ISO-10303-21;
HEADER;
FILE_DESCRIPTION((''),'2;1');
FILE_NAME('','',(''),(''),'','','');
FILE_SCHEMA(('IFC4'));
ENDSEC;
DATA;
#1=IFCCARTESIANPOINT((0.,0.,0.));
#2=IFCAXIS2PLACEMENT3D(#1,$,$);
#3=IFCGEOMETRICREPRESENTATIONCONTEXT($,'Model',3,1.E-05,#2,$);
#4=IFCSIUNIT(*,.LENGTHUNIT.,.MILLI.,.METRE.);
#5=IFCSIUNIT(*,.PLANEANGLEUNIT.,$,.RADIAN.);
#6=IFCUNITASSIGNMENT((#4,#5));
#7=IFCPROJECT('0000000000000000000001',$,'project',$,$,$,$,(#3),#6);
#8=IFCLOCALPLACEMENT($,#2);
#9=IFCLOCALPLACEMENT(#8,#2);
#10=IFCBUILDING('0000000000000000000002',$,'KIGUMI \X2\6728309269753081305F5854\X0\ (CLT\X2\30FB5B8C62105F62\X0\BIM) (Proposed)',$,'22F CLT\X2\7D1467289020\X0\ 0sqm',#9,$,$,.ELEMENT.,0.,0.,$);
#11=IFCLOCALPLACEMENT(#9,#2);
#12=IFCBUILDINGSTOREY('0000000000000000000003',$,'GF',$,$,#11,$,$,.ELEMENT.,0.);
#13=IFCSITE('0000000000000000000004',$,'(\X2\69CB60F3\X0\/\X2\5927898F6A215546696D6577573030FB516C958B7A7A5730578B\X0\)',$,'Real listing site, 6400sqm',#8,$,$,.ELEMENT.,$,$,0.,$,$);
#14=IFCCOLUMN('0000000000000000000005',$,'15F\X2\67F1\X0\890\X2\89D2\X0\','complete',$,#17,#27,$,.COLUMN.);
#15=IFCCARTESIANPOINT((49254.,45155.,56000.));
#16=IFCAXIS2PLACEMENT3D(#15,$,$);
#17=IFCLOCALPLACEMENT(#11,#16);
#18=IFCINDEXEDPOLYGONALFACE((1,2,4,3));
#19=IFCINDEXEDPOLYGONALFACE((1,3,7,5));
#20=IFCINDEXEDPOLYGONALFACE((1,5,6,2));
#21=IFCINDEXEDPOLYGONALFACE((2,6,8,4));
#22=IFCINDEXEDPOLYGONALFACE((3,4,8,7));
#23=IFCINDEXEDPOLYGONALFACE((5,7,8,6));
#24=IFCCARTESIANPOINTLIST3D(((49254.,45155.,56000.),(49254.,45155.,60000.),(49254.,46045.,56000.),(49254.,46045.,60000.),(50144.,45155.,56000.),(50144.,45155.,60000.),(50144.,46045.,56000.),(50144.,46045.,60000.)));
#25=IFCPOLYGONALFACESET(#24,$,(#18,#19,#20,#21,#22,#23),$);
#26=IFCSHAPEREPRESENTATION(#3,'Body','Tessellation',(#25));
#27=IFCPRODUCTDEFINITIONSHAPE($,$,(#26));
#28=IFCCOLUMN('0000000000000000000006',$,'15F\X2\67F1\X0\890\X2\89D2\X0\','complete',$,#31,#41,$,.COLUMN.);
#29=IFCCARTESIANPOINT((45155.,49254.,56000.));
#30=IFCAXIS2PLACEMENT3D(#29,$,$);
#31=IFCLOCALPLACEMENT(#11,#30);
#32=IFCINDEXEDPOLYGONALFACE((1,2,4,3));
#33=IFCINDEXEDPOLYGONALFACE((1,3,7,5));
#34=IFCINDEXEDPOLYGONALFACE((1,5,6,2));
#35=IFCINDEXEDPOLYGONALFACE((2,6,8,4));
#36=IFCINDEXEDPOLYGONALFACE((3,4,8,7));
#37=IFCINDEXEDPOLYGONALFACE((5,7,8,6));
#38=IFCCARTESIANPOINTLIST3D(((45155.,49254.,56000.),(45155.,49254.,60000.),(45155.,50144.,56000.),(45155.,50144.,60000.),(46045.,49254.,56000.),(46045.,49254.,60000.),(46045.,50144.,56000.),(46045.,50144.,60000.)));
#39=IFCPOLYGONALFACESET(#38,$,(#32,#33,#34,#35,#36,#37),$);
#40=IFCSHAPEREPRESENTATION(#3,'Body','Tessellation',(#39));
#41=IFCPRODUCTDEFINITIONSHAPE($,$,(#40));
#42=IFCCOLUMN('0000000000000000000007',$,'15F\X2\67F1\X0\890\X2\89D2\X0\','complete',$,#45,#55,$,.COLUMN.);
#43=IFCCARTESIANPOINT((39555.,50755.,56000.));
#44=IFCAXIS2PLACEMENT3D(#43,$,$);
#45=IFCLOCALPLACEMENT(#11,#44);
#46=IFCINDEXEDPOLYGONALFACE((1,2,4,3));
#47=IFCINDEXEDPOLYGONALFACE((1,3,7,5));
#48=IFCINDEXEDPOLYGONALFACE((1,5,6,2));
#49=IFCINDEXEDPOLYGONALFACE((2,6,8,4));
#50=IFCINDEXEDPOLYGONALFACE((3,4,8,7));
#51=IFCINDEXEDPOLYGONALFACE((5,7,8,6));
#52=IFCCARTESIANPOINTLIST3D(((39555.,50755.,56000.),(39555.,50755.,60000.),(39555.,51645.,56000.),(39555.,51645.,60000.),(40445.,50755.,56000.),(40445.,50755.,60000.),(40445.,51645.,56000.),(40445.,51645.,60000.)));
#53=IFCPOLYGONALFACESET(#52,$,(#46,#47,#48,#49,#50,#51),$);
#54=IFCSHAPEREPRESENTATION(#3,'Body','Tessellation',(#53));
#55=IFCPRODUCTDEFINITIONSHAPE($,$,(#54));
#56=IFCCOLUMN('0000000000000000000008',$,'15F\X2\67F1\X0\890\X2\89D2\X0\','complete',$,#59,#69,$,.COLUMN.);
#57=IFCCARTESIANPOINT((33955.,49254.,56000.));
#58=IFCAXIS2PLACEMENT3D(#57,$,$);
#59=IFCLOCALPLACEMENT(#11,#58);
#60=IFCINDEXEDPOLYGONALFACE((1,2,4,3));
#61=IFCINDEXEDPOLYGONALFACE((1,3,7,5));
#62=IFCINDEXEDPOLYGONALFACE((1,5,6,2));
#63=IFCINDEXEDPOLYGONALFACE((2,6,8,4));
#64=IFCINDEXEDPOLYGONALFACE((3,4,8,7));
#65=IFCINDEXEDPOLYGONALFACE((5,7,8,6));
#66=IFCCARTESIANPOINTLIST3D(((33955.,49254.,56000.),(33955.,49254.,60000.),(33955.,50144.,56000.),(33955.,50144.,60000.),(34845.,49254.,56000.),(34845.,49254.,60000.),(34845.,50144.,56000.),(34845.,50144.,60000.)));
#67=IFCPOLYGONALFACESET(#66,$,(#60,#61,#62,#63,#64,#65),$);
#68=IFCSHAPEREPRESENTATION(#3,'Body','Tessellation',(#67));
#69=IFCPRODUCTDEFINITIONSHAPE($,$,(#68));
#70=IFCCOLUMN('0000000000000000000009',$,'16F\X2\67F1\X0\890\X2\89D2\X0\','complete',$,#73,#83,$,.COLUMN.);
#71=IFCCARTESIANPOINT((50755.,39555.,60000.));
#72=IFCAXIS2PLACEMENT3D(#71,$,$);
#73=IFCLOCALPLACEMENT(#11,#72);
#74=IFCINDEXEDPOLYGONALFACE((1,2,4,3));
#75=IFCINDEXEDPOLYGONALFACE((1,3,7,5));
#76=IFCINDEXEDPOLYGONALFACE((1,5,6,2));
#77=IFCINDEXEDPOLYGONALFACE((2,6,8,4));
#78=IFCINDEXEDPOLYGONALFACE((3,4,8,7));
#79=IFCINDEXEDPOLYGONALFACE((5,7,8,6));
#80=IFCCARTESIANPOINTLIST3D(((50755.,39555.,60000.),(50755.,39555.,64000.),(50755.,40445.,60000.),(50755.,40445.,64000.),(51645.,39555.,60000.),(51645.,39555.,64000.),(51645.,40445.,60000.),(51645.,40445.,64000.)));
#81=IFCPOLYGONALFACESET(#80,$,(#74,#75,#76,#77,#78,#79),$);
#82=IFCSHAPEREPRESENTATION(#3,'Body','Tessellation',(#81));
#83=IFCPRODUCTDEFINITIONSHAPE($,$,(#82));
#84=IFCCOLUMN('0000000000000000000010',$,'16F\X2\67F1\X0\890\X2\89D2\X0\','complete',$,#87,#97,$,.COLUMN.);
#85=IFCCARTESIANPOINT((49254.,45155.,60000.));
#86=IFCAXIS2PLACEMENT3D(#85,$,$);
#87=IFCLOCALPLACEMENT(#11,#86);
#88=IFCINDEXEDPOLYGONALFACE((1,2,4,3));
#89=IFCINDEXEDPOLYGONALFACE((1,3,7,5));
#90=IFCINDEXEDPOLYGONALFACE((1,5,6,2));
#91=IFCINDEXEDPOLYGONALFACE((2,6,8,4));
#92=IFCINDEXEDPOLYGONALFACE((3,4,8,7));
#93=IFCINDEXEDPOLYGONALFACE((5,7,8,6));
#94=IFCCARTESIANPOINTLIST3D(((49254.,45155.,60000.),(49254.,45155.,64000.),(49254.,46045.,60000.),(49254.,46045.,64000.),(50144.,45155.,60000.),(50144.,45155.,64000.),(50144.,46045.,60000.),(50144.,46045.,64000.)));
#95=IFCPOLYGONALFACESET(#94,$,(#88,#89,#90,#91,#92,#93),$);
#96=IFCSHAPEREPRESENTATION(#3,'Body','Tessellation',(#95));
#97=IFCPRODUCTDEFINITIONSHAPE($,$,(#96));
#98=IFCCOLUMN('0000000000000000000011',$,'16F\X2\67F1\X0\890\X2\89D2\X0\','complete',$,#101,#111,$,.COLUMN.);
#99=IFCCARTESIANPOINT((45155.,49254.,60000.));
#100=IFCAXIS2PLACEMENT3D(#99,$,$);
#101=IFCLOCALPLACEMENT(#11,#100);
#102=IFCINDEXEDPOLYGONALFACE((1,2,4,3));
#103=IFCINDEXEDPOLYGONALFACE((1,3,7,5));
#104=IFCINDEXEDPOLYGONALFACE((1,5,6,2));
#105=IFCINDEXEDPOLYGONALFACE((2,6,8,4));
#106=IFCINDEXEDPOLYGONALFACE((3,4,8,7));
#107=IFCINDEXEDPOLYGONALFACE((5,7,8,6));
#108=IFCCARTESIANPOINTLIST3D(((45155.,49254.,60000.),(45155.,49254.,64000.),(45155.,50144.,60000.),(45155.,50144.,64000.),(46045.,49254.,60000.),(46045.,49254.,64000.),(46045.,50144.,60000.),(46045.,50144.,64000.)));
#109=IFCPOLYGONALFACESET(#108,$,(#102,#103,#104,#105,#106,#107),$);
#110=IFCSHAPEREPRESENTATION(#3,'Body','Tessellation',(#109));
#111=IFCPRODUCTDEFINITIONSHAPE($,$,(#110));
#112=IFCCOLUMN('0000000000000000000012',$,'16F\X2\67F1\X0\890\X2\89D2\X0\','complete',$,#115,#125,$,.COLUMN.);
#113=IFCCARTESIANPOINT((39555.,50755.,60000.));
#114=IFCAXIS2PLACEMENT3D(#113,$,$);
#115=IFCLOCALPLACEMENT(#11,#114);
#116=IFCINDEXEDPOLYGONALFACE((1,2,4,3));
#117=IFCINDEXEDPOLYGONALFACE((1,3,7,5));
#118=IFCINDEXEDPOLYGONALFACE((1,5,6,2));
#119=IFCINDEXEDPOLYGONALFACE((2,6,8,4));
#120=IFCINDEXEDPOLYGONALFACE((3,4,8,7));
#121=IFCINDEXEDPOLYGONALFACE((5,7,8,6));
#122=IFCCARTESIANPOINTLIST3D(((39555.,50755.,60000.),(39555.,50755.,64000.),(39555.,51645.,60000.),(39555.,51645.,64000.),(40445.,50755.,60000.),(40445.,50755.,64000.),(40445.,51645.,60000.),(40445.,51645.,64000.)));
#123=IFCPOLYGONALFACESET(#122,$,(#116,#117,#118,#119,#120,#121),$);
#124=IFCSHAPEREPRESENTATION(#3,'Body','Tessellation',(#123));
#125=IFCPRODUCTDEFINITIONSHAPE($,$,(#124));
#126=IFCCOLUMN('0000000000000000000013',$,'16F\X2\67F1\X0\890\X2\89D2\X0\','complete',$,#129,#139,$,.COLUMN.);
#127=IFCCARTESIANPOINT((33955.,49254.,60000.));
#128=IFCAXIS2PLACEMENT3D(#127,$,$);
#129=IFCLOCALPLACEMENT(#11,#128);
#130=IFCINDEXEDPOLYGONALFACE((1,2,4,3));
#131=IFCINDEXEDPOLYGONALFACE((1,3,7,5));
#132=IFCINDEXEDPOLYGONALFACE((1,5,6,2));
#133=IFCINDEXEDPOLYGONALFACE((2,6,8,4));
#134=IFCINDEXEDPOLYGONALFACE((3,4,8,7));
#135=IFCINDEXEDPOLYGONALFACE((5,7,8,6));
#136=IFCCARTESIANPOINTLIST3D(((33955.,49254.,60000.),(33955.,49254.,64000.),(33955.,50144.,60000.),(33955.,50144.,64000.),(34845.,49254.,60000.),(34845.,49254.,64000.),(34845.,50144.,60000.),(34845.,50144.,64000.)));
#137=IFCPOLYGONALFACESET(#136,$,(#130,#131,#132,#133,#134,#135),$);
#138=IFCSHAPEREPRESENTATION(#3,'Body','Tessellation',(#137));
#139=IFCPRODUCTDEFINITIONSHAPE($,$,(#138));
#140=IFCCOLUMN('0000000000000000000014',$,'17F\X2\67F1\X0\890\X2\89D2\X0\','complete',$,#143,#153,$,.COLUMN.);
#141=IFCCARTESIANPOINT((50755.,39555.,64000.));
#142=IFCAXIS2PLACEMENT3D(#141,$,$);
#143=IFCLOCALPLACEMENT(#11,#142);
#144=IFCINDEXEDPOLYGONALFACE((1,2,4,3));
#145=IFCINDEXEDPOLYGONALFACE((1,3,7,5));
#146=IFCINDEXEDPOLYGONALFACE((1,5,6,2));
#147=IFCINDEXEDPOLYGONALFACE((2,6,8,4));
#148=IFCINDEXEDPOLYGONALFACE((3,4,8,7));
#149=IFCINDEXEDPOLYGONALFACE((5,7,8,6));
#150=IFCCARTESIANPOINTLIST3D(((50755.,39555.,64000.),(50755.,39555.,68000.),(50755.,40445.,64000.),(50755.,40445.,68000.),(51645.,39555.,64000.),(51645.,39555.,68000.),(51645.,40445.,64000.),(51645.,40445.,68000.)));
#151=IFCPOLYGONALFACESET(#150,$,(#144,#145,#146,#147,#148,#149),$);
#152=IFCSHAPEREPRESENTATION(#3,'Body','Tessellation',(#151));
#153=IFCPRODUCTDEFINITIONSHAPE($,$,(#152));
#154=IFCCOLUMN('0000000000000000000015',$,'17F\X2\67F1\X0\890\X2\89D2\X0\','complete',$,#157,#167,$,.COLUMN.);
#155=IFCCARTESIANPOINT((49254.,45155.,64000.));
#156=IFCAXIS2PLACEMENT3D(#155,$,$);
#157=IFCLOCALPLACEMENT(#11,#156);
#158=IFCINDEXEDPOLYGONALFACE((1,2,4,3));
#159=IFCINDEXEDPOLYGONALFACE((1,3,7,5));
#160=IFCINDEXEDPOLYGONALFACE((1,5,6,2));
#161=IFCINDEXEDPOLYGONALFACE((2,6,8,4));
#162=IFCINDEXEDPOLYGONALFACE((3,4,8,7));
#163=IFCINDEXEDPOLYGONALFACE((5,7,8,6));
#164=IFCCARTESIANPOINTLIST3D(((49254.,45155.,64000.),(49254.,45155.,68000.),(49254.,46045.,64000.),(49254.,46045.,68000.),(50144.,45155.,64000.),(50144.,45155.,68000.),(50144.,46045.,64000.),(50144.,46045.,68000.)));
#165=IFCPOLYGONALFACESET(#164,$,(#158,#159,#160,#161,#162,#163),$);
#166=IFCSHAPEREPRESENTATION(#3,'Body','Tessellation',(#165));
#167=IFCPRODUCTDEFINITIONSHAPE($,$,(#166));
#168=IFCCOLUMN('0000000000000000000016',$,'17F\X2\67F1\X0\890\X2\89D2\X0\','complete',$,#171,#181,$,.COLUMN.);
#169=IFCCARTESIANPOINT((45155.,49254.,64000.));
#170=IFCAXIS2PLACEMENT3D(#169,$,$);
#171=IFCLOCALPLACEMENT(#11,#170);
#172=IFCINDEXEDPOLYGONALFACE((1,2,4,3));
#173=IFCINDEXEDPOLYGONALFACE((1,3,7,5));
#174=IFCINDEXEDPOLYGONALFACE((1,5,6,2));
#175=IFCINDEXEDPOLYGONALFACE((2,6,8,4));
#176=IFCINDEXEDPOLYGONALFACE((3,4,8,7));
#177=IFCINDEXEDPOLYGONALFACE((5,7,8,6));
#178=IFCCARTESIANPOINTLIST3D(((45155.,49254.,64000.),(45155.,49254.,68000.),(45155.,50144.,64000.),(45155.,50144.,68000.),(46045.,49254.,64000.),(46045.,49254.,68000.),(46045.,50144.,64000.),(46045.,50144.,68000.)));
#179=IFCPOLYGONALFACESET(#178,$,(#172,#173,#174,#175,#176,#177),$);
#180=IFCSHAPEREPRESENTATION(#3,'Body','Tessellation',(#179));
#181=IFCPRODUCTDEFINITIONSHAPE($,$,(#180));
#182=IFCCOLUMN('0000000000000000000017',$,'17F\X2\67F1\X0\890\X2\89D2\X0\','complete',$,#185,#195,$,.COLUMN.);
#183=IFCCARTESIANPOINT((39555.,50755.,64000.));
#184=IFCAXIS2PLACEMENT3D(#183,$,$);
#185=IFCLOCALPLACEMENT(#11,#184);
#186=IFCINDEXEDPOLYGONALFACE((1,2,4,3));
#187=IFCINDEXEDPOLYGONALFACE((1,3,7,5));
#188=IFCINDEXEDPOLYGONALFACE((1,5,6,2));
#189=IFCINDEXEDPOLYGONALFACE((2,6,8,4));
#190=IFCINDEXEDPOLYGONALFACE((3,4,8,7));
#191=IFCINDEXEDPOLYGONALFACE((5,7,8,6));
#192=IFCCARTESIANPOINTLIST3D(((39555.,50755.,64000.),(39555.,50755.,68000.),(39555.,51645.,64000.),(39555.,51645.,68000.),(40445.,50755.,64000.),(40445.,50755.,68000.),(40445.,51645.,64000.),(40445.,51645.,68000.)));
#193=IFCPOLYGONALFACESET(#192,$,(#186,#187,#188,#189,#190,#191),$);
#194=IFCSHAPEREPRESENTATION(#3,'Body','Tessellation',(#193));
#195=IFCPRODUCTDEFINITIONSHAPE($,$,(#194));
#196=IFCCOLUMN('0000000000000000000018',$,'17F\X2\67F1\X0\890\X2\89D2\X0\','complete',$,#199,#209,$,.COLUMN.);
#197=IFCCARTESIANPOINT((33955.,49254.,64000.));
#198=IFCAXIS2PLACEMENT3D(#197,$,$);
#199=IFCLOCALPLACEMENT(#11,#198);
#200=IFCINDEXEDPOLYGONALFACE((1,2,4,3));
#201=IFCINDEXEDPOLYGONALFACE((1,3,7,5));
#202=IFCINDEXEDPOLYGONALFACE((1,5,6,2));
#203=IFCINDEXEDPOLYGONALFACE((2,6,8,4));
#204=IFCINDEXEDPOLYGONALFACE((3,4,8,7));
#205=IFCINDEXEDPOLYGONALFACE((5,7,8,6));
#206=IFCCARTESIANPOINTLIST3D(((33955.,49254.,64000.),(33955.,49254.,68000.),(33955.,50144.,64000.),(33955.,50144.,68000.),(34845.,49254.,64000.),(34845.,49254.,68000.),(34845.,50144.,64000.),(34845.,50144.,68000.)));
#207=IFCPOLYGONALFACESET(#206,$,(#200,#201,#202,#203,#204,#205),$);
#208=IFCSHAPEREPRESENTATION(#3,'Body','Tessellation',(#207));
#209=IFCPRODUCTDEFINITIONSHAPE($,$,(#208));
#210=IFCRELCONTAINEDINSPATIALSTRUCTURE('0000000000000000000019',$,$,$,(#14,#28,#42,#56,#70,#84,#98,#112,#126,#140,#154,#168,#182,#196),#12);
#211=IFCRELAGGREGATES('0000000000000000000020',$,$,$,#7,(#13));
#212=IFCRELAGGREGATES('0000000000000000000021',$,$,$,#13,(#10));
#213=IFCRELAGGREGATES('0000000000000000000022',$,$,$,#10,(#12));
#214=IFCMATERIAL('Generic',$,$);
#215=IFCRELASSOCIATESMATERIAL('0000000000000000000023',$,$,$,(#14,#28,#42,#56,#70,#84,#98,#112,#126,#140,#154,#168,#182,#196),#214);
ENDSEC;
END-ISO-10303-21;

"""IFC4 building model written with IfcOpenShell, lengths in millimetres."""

from ifc_helpers import new_model, si_unit, frame, frame_2d, origin, place, context, project, spatial, rectangle, extrude, material, element, save


model = new_model("IFC4")

# Units and contexts
model_context = context("Model", 3, precision=1e-05, world=origin())
ifc_project = project(units=[si_unit("LENGTHUNIT", "METRE", prefix="MILLI"), si_unit("PLANEANGLEUNIT", "RADIAN")], contexts=[model_context])

# Site, building, storey
site_placement = place(None, origin())
site = spatial("IfcSite", under=ifc_project, at=site_placement, Name="(構想/大規模商業敷地・公開空地型)", ObjectType="Real listing site, 6400sqm", CompositionType="ELEMENT", RefElevation=0.0)
building_placement = place(site_placement, origin())
building = spatial("IfcBuilding", under=site, at=building_placement, Name="KIGUMI 木を極めた塔 (CLT・完成形BIM) (Proposed)", ObjectType="22F CLT純木造 0sqm", CompositionType="ELEMENT", ElevationOfRefHeight=0.0, ElevationOfTerrain=0.0)
storey_placement = place(building_placement, origin())
storey = spatial("IfcBuildingStorey", under=building, at=storey_placement, Name="GF", CompositionType="ELEMENT", Elevation=0.0)

# Columns
ifc_material = material(Name="Generic")
column_1_placement = place(storey_placement, frame((49254.0, 45155.0, 56000.0)))
element("IfcColumn", 1, at=column_1_placement, inside=storey, material=ifc_material, Name="15F柱890角", Description="complete", PredefinedType="COLUMN", context=model_context, shape_type="SweptSolid", body=[
    extrude(rectangle(XDim=890.0, YDim=890.0, at=frame_2d((445.0, 445.0))), frame((49254.0, 45155.0, 56000.0)), (0.0, 0.0, 1.0), 4000.0),
])
column_2_placement = place(storey_placement, frame((45155.0, 49254.0, 56000.0)))
element("IfcColumn", 2, at=column_2_placement, inside=storey, material=ifc_material, Name="15F柱890角", Description="complete", PredefinedType="COLUMN", context=model_context, shape_type="SweptSolid", body=[
    extrude(rectangle(XDim=890.0, YDim=890.0, at=frame_2d((445.0, 445.0))), frame((45155.0, 49254.0, 56000.0)), (0.0, 0.0, 1.0), 4000.0),
])
column_3_placement = place(storey_placement, frame((39555.0, 50755.0, 56000.0)))
element("IfcColumn", 3, at=column_3_placement, inside=storey, material=ifc_material, Name="15F柱890角", Description="complete", PredefinedType="COLUMN", context=model_context, shape_type="SweptSolid", body=[
    extrude(rectangle(XDim=890.0, YDim=890.0, at=frame_2d((445.0, 445.0))), frame((39555.0, 50755.0, 56000.0)), (0.0, 0.0, 1.0), 4000.0),
])
column_4_placement = place(storey_placement, frame((33955.0, 49254.0, 56000.0)))
element("IfcColumn", 4, at=column_4_placement, inside=storey, material=ifc_material, Name="15F柱890角", Description="complete", PredefinedType="COLUMN", context=model_context, shape_type="SweptSolid", body=[
    extrude(rectangle(XDim=890.0, YDim=890.0, at=frame_2d((445.0, 445.0))), frame((33955.0, 49254.0, 56000.0)), (0.0, 0.0, 1.0), 4000.0),
])
column_5_placement = place(storey_placement, frame((50755.0, 39555.0, 60000.0)))
element("IfcColumn", 5, at=column_5_placement, inside=storey, material=ifc_material, Name="16F柱890角", Description="complete", PredefinedType="COLUMN", context=model_context, shape_type="SweptSolid", body=[
    extrude(rectangle(XDim=890.0, YDim=890.0, at=frame_2d((445.0, 445.0))), frame((50755.0, 39555.0, 60000.0)), (0.0, 0.0, 1.0), 4000.0),
])
column_6_placement = place(storey_placement, frame((49254.0, 45155.0, 60000.0)))
element("IfcColumn", 6, at=column_6_placement, inside=storey, material=ifc_material, Name="16F柱890角", Description="complete", PredefinedType="COLUMN", context=model_context, shape_type="SweptSolid", body=[
    extrude(rectangle(XDim=890.0, YDim=890.0, at=frame_2d((445.0, 445.0))), frame((49254.0, 45155.0, 60000.0)), (0.0, 0.0, 1.0), 4000.0),
])
column_7_placement = place(storey_placement, frame((45155.0, 49254.0, 60000.0)))
element("IfcColumn", 7, at=column_7_placement, inside=storey, material=ifc_material, Name="16F柱890角", Description="complete", PredefinedType="COLUMN", context=model_context, shape_type="SweptSolid", body=[
    extrude(rectangle(XDim=890.0, YDim=890.0, at=frame_2d((445.0, 445.0))), frame((45155.0, 49254.0, 60000.0)), (0.0, 0.0, 1.0), 4000.0),
])
column_8_placement = place(storey_placement, frame((39555.0, 50755.0, 60000.0)))
element("IfcColumn", 8, at=column_8_placement, inside=storey, material=ifc_material, Name="16F柱890角", Description="complete", PredefinedType="COLUMN", context=model_context, shape_type="SweptSolid", body=[
    extrude(rectangle(XDim=890.0, YDim=890.0, at=frame_2d((445.0, 445.0))), frame((39555.0, 50755.0, 60000.0)), (0.0, 0.0, 1.0), 4000.0),
])
column_9_placement = place(storey_placement, frame((33955.0, 49254.0, 60000.0)))
element("IfcColumn", 9, at=column_9_placement, inside=storey, material=ifc_material, Name="16F柱890角", Description="complete", PredefinedType="COLUMN", context=model_context, shape_type="SweptSolid", body=[
    extrude(rectangle(XDim=890.0, YDim=890.0, at=frame_2d((445.0, 445.0))), frame((33955.0, 49254.0, 60000.0)), (0.0, 0.0, 1.0), 4000.0),
])
column_10_placement = place(storey_placement, frame((50755.0, 39555.0, 64000.0)))
element("IfcColumn", 10, at=column_10_placement, inside=storey, material=ifc_material, Name="17F柱890角", Description="complete", PredefinedType="COLUMN", context=model_context, shape_type="SweptSolid", body=[
    extrude(rectangle(XDim=890.0, YDim=890.0, at=frame_2d((445.0, 445.0))), frame((50755.0, 39555.0, 64000.0)), (0.0, 0.0, 1.0), 4000.0),
])
column_11_placement = place(storey_placement, frame((49254.0, 45155.0, 64000.0)))
element("IfcColumn", 11, at=column_11_placement, inside=storey, material=ifc_material, Name="17F柱890角", Description="complete", PredefinedType="COLUMN", context=model_context, shape_type="SweptSolid", body=[
    extrude(rectangle(XDim=890.0, YDim=890.0, at=frame_2d((445.0, 445.0))), frame((49254.0, 45155.0, 64000.0)), (0.0, 0.0, 1.0), 4000.0),
])
column_12_placement = place(storey_placement, frame((45155.0, 49254.0, 64000.0)))
element("IfcColumn", 12, at=column_12_placement, inside=storey, material=ifc_material, Name="17F柱890角", Description="complete", PredefinedType="COLUMN", context=model_context, shape_type="SweptSolid", body=[
    extrude(rectangle(XDim=890.0, YDim=890.0, at=frame_2d((445.0, 445.0))), frame((45155.0, 49254.0, 64000.0)), (0.0, 0.0, 1.0), 4000.0),
])
column_13_placement = place(storey_placement, frame((39555.0, 50755.0, 64000.0)))
element("IfcColumn", 13, at=column_13_placement, inside=storey, material=ifc_material, Name="17F柱890角", Description="complete", PredefinedType="COLUMN", context=model_context, shape_type="SweptSolid", body=[
    extrude(rectangle(XDim=890.0, YDim=890.0, at=frame_2d((445.0, 445.0))), frame((39555.0, 50755.0, 64000.0)), (0.0, 0.0, 1.0), 4000.0),
])
column_14_placement = place(storey_placement, frame((33955.0, 49254.0, 64000.0)))
element("IfcColumn", 14, at=column_14_placement, inside=storey, material=ifc_material, Name="17F柱890角", Description="complete", PredefinedType="COLUMN", context=model_context, shape_type="SweptSolid", body=[
    extrude(rectangle(XDim=890.0, YDim=890.0, at=frame_2d((445.0, 445.0))), frame((33955.0, 49254.0, 64000.0)), (0.0, 0.0, 1.0), 4000.0),
])

save(model, "model.ifc")
